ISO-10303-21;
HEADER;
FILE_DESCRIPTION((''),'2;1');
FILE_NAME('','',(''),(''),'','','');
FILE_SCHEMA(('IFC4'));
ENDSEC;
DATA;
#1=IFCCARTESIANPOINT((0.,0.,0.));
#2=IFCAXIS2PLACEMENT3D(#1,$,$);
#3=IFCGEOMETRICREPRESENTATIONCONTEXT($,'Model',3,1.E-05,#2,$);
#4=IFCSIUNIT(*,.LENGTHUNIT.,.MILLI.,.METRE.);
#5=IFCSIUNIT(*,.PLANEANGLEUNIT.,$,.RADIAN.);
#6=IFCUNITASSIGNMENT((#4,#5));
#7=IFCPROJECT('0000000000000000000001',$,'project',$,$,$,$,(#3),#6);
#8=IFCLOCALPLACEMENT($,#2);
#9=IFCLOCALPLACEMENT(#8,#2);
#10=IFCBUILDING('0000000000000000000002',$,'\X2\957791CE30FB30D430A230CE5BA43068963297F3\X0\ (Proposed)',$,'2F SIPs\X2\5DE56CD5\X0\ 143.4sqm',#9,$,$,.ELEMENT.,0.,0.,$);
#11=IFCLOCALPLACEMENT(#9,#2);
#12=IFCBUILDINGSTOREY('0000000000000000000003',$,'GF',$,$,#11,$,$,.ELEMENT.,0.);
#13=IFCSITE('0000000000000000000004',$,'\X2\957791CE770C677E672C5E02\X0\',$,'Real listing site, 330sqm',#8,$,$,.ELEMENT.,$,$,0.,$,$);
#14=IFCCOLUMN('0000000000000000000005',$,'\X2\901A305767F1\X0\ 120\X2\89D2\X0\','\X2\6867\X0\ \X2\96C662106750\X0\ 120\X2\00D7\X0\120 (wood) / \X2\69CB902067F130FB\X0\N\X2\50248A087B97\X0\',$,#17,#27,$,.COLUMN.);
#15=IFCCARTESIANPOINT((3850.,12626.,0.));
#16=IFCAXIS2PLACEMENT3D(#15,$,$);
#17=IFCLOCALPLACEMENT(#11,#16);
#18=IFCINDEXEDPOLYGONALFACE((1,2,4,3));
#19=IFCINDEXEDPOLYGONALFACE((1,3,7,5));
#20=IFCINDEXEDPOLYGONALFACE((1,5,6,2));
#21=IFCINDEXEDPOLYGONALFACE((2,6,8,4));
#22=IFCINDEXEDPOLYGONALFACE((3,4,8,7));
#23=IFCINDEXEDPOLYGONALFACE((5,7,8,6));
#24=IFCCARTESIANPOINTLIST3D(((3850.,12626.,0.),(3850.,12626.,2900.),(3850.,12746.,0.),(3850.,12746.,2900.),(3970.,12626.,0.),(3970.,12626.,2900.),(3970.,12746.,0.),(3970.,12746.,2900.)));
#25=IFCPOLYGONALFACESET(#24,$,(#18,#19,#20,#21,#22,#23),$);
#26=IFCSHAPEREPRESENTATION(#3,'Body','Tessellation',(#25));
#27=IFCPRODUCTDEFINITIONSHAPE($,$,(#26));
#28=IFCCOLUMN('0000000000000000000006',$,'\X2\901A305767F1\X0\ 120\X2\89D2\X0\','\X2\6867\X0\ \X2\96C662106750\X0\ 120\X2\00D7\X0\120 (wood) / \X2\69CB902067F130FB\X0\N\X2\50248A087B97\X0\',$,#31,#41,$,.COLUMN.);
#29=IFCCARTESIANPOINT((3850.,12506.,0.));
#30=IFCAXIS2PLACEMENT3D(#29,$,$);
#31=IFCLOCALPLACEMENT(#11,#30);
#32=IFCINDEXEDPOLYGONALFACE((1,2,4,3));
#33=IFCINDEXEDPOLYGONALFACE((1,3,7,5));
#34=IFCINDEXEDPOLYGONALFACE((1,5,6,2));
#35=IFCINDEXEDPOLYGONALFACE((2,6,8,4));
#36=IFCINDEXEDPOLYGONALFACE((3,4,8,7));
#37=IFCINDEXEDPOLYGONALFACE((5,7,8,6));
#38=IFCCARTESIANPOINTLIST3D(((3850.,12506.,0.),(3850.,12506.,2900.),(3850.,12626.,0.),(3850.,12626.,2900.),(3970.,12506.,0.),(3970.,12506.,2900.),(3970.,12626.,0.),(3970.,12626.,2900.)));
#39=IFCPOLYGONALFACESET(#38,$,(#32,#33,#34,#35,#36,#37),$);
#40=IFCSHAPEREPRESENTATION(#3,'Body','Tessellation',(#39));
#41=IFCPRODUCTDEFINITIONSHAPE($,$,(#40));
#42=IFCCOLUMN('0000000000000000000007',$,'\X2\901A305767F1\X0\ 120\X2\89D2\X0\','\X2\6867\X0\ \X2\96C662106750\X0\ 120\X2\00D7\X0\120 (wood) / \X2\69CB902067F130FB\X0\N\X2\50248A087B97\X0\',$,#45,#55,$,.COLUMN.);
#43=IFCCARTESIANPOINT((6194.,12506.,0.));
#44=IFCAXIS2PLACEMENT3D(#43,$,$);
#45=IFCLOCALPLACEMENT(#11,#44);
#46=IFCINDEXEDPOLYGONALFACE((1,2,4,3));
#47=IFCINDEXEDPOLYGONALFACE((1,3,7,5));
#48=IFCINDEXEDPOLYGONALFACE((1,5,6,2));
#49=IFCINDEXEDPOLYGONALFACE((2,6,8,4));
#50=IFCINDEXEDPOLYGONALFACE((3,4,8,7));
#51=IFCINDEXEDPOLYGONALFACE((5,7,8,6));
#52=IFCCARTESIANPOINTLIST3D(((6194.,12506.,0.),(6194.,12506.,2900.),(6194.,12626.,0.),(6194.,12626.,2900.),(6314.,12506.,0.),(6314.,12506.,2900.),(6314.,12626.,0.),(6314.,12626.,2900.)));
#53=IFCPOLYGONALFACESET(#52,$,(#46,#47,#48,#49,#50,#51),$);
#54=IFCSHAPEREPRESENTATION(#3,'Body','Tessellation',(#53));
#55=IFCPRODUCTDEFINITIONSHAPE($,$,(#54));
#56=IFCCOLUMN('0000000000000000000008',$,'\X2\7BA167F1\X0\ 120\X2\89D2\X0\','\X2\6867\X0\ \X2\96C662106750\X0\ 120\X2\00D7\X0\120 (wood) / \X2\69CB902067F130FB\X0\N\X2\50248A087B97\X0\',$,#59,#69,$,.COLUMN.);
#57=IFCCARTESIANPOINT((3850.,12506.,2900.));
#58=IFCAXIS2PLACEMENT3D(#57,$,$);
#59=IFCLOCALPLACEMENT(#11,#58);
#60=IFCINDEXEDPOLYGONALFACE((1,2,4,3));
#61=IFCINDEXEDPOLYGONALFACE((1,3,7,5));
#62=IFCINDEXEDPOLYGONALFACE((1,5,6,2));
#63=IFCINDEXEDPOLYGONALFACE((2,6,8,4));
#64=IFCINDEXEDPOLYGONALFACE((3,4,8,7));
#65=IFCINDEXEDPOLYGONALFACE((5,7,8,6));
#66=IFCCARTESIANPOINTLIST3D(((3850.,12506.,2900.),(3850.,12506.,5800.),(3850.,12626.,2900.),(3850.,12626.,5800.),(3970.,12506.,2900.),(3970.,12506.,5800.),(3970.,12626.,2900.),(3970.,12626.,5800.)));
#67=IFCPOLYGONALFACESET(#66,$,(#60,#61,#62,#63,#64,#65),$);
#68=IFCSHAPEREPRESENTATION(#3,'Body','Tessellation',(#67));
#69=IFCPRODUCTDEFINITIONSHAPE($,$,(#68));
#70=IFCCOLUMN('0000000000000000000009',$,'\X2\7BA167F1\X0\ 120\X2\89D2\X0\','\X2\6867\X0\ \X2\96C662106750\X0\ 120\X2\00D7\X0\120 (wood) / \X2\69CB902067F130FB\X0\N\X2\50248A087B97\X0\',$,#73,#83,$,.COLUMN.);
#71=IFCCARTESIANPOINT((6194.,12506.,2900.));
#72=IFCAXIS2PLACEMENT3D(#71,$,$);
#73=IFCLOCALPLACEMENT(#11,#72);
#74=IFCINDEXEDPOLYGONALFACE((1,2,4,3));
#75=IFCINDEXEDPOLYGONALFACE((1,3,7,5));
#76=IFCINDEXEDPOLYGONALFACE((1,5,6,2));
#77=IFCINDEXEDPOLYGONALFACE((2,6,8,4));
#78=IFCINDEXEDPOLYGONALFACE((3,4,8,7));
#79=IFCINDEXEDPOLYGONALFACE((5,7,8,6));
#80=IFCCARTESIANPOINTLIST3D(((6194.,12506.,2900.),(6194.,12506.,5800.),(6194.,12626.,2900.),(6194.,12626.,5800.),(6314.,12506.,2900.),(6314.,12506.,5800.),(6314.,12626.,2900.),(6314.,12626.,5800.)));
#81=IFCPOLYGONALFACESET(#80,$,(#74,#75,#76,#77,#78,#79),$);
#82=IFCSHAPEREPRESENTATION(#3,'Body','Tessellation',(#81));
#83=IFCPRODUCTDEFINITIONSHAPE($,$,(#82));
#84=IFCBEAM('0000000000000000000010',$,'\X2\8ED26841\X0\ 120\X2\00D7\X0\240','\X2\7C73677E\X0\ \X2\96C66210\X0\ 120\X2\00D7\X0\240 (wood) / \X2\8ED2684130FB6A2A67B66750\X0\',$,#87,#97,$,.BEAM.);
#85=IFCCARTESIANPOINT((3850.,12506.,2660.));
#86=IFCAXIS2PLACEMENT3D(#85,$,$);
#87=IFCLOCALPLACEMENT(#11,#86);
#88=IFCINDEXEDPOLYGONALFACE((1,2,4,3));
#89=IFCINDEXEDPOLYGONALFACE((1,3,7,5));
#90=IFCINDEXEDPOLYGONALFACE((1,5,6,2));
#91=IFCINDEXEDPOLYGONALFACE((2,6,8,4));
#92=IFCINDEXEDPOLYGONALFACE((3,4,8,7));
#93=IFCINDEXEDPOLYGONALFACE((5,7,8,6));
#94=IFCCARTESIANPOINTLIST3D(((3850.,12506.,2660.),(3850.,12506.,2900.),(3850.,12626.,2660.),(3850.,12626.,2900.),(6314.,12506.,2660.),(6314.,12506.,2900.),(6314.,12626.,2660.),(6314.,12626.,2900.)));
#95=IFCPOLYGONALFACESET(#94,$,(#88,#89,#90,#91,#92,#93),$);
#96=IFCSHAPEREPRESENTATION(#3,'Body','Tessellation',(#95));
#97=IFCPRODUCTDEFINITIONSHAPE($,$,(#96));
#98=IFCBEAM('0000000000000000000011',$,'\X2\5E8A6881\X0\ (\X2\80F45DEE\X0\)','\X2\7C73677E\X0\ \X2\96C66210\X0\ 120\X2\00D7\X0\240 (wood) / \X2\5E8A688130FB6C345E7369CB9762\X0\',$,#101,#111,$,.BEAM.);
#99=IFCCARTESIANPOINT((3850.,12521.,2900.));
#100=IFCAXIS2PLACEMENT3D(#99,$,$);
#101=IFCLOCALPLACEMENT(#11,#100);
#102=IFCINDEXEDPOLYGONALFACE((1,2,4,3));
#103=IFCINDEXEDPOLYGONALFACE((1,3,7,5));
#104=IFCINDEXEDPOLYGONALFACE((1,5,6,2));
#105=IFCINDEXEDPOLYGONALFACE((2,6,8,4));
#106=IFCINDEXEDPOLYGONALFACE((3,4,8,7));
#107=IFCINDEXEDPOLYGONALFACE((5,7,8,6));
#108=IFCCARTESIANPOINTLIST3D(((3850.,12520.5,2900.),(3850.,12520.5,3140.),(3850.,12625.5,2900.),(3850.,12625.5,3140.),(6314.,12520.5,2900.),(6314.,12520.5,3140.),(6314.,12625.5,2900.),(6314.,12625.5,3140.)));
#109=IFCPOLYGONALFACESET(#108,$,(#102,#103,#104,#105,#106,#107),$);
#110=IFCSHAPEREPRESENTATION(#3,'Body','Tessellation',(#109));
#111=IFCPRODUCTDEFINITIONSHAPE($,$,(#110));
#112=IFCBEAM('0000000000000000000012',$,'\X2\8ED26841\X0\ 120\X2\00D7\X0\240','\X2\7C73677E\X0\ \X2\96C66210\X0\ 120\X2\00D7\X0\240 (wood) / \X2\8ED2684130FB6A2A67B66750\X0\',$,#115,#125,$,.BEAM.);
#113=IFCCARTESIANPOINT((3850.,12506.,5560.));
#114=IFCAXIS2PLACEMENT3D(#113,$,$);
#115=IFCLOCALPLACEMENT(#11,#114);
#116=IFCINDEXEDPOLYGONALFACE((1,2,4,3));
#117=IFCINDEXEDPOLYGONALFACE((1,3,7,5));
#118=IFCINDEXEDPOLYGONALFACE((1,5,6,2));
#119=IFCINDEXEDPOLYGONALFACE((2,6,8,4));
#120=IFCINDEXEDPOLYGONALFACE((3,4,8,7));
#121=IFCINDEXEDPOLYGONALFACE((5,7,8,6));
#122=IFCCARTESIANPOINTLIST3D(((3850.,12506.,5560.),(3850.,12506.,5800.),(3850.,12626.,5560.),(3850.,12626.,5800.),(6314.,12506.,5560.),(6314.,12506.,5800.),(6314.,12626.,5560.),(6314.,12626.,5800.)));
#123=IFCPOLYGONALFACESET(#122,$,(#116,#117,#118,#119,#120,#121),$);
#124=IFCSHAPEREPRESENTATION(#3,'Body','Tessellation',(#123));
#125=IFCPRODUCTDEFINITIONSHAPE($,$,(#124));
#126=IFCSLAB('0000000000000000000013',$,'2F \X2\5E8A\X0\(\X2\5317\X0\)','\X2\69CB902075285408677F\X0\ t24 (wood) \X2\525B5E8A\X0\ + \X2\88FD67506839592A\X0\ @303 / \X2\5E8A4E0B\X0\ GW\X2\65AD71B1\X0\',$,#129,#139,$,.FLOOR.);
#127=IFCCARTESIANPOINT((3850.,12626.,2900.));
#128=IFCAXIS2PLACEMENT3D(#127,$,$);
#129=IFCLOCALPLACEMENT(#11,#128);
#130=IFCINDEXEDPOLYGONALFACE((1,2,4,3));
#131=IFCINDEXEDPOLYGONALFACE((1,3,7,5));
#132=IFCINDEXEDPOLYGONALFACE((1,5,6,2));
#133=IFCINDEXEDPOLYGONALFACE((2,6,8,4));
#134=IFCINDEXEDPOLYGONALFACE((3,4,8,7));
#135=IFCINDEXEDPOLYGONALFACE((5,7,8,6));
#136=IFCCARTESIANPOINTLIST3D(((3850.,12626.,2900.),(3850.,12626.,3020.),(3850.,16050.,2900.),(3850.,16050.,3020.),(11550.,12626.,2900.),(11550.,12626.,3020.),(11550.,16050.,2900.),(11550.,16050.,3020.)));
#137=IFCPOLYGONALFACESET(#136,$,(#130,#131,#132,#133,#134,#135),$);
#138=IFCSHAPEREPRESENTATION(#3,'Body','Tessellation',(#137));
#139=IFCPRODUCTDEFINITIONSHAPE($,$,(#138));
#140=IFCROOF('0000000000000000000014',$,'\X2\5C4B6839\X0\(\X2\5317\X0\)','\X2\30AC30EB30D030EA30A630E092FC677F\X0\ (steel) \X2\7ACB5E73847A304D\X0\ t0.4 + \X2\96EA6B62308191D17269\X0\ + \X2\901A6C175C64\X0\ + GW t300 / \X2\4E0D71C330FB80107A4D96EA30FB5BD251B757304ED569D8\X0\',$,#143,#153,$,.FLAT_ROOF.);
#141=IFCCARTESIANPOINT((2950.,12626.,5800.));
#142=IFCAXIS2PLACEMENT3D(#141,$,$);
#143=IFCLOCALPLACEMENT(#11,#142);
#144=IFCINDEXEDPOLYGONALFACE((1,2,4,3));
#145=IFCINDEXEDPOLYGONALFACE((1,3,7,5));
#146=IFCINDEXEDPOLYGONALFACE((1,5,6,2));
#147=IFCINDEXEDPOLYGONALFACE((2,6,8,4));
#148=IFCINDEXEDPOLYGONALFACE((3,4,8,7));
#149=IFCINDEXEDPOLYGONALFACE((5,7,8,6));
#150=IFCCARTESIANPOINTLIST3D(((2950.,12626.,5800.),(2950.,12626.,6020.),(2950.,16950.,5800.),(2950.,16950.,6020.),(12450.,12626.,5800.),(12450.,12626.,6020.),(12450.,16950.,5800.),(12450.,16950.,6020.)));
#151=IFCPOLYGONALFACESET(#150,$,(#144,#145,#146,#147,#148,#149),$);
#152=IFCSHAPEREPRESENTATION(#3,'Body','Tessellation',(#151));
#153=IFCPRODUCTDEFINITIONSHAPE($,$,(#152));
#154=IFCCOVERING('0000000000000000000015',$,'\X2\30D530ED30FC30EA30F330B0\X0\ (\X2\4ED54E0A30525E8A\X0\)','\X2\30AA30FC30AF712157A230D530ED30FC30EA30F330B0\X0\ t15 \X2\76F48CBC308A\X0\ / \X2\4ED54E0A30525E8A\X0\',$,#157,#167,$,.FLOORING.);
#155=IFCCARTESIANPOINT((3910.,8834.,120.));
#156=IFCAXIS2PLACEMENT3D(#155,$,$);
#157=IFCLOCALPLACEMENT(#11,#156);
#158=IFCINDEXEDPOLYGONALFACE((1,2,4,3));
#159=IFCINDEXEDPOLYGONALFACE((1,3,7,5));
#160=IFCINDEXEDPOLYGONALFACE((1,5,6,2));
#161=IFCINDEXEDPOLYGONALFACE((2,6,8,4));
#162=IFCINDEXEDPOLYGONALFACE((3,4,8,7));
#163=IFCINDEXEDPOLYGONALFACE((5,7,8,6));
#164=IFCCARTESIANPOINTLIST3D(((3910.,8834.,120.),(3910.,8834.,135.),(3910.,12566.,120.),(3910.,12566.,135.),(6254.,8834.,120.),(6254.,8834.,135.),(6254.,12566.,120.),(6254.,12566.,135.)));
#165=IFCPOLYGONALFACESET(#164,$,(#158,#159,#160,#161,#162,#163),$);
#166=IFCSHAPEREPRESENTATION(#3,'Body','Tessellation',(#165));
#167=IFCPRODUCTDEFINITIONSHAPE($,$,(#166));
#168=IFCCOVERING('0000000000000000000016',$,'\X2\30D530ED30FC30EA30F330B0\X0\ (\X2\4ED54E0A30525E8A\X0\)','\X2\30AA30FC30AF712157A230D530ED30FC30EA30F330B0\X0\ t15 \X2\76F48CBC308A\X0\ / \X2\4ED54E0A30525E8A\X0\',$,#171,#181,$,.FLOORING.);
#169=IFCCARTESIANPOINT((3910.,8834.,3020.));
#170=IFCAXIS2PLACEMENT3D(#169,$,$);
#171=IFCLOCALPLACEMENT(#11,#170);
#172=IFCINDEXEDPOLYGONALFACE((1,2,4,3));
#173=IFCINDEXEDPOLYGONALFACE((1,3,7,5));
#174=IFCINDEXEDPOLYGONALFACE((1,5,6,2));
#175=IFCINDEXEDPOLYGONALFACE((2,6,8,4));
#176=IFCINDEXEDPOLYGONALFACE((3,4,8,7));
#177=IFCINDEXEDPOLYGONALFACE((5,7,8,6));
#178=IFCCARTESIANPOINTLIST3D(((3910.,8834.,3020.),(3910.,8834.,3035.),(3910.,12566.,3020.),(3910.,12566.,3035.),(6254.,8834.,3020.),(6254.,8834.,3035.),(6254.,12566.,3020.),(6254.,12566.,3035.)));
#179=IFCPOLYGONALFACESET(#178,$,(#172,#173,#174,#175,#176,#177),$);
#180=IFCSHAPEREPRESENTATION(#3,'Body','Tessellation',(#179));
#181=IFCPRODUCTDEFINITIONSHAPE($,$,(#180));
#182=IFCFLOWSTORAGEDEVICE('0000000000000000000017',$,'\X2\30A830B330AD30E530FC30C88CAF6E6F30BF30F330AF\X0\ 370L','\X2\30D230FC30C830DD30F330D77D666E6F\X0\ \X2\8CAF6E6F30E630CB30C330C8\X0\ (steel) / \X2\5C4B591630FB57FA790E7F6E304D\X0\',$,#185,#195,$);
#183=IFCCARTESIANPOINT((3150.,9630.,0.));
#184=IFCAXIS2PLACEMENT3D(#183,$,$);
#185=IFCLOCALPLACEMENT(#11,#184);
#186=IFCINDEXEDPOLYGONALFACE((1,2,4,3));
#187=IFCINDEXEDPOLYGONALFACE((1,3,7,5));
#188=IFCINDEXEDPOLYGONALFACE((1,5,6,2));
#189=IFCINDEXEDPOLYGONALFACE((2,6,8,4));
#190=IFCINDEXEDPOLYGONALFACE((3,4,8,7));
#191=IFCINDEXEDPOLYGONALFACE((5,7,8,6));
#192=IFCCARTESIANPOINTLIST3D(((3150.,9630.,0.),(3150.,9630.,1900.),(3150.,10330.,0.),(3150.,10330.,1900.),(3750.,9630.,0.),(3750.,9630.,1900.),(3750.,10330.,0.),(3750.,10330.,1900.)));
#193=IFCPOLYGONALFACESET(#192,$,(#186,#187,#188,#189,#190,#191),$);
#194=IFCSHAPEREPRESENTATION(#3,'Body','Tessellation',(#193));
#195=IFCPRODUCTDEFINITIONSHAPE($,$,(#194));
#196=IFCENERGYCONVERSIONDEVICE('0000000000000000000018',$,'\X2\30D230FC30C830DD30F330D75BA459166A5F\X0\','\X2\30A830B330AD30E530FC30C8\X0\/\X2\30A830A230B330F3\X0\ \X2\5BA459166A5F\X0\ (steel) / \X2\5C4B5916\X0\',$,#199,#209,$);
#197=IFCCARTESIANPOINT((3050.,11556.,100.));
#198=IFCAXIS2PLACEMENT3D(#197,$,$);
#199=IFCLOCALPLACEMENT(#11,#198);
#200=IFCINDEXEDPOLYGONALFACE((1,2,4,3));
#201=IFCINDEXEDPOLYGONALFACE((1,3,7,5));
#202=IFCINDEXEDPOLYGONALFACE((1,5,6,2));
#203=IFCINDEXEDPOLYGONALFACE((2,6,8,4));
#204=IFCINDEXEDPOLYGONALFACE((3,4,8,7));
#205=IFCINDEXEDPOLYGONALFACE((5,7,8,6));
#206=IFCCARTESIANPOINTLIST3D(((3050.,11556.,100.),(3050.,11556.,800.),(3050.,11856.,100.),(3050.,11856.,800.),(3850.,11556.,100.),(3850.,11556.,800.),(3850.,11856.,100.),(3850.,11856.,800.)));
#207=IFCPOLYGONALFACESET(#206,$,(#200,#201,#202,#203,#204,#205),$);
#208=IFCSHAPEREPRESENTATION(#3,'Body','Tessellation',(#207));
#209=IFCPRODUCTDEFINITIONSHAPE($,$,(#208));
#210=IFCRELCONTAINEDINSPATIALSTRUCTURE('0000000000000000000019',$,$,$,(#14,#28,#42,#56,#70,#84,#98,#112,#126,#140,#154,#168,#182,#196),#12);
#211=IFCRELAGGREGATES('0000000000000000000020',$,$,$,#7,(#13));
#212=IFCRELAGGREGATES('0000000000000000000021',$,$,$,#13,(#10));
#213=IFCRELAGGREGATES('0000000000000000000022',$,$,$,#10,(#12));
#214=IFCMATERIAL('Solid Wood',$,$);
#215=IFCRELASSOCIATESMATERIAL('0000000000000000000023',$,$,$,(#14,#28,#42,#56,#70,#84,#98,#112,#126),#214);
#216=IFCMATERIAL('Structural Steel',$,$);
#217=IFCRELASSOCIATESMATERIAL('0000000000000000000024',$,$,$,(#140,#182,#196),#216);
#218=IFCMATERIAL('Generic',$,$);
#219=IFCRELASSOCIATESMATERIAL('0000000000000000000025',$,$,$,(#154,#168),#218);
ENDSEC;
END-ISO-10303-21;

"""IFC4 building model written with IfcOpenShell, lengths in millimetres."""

from ifc_helpers import new_model, si_unit, frame, frame_2d, origin, place, context, project, spatial, rectangle, extrude, material, element, save


model = new_model("IFC4")

# Units and contexts
model_context = context("Model", 3, precision=1e-05, world=origin())
ifc_project = project(units=[si_unit("LENGTHUNIT", "METRE", prefix="MILLI"), si_unit("PLANEANGLEUNIT", "RADIAN")], contexts=[model_context])

# Site, building, storey
site_placement = place(None, origin())
site = spatial("IfcSite", under=ifc_project, at=site_placement, Name="長野県松本市", ObjectType="Real listing site, 330sqm", CompositionType="ELEMENT", RefElevation=0.0)
building_placement = place(site_placement, origin())
building = spatial("IfcBuilding", under=site, at=building_placement, Name="長野・ピアノ室と防音 (Proposed)", ObjectType="2F SIPs工法 143.4sqm", CompositionType="ELEMENT", ElevationOfRefHeight=0.0, ElevationOfTerrain=0.0)
storey_placement = place(building_placement, origin())
storey = spatial("IfcBuildingStorey", under=building, at=storey_placement, Name="GF", CompositionType="ELEMENT", Elevation=0.0)

# Columns
ifc_material_1 = material(Name="Solid Wood")
column_1_placement = place(storey_placement, frame((3850.0, 12626.0, 0.0)))
element("IfcColumn", 1, at=column_1_placement, inside=storey, material=ifc_material_1, Name="通し柱 120角", Description="桧 集成材 120×120 (wood) / 構造柱・N値計算", PredefinedType="COLUMN", context=model_context, shape_type="SweptSolid", body=[
    extrude(rectangle(XDim=120.0, YDim=120.0, at=frame_2d((60.0, 60.0))), frame((3850.0, 12626.0, 0.0)), (0.0, 0.0, 1.0), 2900.0),
])
column_2_placement = place(storey_placement, frame((3850.0, 12506.0, 0.0)))
element("IfcColumn", 2, at=column_2_placement, inside=storey, material=ifc_material_1, Name="通し柱 120角", Description="桧 集成材 120×120 (wood) / 構造柱・N値計算", PredefinedType="COLUMN", context=model_context, shape_type="SweptSolid", body=[
    extrude(rectangle(XDim=120.0, YDim=120.0, at=frame_2d((60.0, 60.0))), frame((3850.0, 12506.0, 0.0)), (0.0, 0.0, 1.0), 2900.0),
])
column_3_placement = place(storey_placement, frame((6194.0, 12506.0, 0.0)))
element("IfcColumn", 3, at=column_3_placement, inside=storey, material=ifc_material_1, Name="通し柱 120角", Description="桧 集成材 120×120 (wood) / 構造柱・N値計算", PredefinedType="COLUMN", context=model_context, shape_type="SweptSolid", body=[
    extrude(rectangle(XDim=120.0, YDim=120.0, at=frame_2d((60.0, 60.0))), frame((6194.0, 12506.0, 0.0)), (0.0, 0.0, 1.0), 2900.0),
])
column_4_placement = place(storey_placement, frame((3850.0, 12506.0, 2900.0)))
element("IfcColumn", 4, at=column_4_placement, inside=storey, material=ifc_material_1, Name="管柱 120角", Description="桧 集成材 120×120 (wood) / 構造柱・N値計算", PredefinedType="COLUMN", context=model_context, shape_type="SweptSolid", body=[
    extrude(rectangle(XDim=120.0, YDim=120.0, at=frame_2d((60.0, 60.0))), frame((3850.0, 12506.0, 2900.0)), (0.0, 0.0, 1.0), 2900.0),
])
column_5_placement = place(storey_placement, frame((6194.0, 12506.0, 2900.0)))
element("IfcColumn", 5, at=column_5_placement, inside=storey, material=ifc_material_1, Name="管柱 120角", Description="桧 集成材 120×120 (wood) / 構造柱・N値計算", PredefinedType="COLUMN", context=model_context, shape_type="SweptSolid", body=[
    extrude(rectangle(XDim=120.0, YDim=120.0, at=frame_2d((60.0, 60.0))), frame((6194.0, 12506.0, 2900.0)), (0.0, 0.0, 1.0), 2900.0),
])

# Beams
beam_1_placement = place(storey_placement, frame((3850.0, 12506.0, 2660.0)))
element("IfcBeam", 6, at=beam_1_placement, inside=storey, material=ifc_material_1, Name="軒桁 120×240", Description="米松 集成 120×240 (wood) / 軒桁・横架材", PredefinedType="BEAM", context=model_context, shape_type="SweptSolid", body=[
    extrude(rectangle(XDim=2464.0, YDim=120.0, at=frame_2d((1232.0, 60.0))), frame((3850.0, 12506.0, 2660.0)), (0.0, 0.0, 1.0), 240.0),
])
beam_2_placement = place(storey_placement, frame((3850.0, 12521.0, 2900.0)))
element("IfcBeam", 7, at=beam_2_placement, inside=storey, material=ifc_material_1, Name="床梁 (胴差)", Description="米松 集成 120×240 (wood) / 床梁・水平構面", PredefinedType="BEAM", context=model_context, shape_type="SweptSolid", body=[
    extrude(rectangle(XDim=2464.0, YDim=105.0, at=frame_2d((1232.0, 52.0))), frame((3850.0, 12521.0, 2900.0)), (0.0, 0.0, 1.0), 240.0),
])
beam_3_placement = place(storey_placement, frame((3850.0, 12506.0, 5560.0)))
element("IfcBeam", 8, at=beam_3_placement, inside=storey, material=ifc_material_1, Name="軒桁 120×240", Description="米松 集成 120×240 (wood) / 軒桁・横架材", PredefinedType="BEAM", context=model_context, shape_type="SweptSolid", body=[
    extrude(rectangle(XDim=2464.0, YDim=120.0, at=frame_2d((1232.0, 60.0))), frame((3850.0, 12506.0, 5560.0)), (0.0, 0.0, 1.0), 240.0),
])

# Slab
slab_1_placement = place(storey_placement, frame((3850.0, 12626.0, 2900.0)))
element("IfcSlab", 9, at=slab_1_placement, inside=storey, material=ifc_material_1, Name="2F 床(北)", Description="構造用合板 t24 (wood) 剛床 + 製材根太 @303 / 床下 GW断熱", PredefinedType="FLOOR", context=model_context, shape_type="SweptSolid", body=[
    extrude(rectangle(XDim=7700.0, YDim=3424.0, at=frame_2d((3850.0, 1712.0))), frame((3850.0, 12626.0, 2900.0)), (0.0, 0.0, 1.0), 120.0),
])

# Roof
ifc_material_2 = material(Name="Structural Steel")
for number, where, name in (
    (10, (2950.0, 12626.0, 5800.0), "屋根(北)"),
):
    element("IfcRoof", number, at=place(storey_placement, frame(where)), inside=storey, material=ifc_material_2, Name=name, Description="ガルバリウム鋼板 (steel) 立平葺き t0.4 + 雪止め金物 + 通気層 + GW t300 / 不燃・耐積雪・寒冷地仕様", PredefinedType="FLAT_ROOF", context=model_context, shape_type="SweptSolid", body=[
        extrude(rectangle(XDim=9500.0, YDim=4324.0, at=frame_2d((4750.0, 2162.0))), frame((2950.0, 12626.0, 5800.0)), (0.0, 0.0, 1.0), 220.0),
    ])

# Coverings
ifc_material_3 = material(Name="Generic")
covering_1_placement = place(storey_placement, frame((3910.0, 8834.0, 120.0)))
element("IfcCovering", 11, at=covering_1_placement, inside=storey, material=ifc_material_3, Name="フローリング (仕上げ床)", Description="オーク無垢フローリング t15 直貼り / 仕上げ床", PredefinedType="FLOORING", context=model_context, shape_type="SweptSolid", body=[
    extrude(rectangle(XDim=2344.0, YDim=3732.0, at=frame_2d((1172.0, 1866.0))), frame((3910.0, 8834.0, 120.0)), (0.0, 0.0, 1.0), 15.0),
])
covering_2_placement = place(storey_placement, frame((3910.0, 8834.0, 3020.0)))
element("IfcCovering", 12, at=covering_2_placement, inside=storey, material=ifc_material_3, Name="フローリング (仕上げ床)", Description="オーク無垢フローリング t15 直貼り / 仕上げ床", PredefinedType="FLOORING", context=model_context, shape_type="SweptSolid", body=[
    extrude(rectangle(XDim=2344.0, YDim=3732.0, at=frame_2d((1172.0, 1866.0))), frame((3910.0, 8834.0, 3020.0)), (0.0, 0.0, 1.0), 15.0),
])

# Flow storage device
flow_storage_device_placement = place(storey_placement, frame((3150.0, 9630.0, 0.0)))
element("IfcFlowStorageDevice", 13, at=flow_storage_device_placement, inside=storey, material=ifc_material_2, Name="エコキュート貯湯タンク 370L", Description="ヒートポンプ給湯 貯湯ユニット (steel) / 屋外・基礎置き", context=model_context, shape_type="SweptSolid", body=[
    extrude(rectangle(XDim=600.0, YDim=700.0, at=frame_2d((300.0, 350.0))), frame((3150.0, 9630.0, 0.0)), (0.0, 0.0, 1.0), 1900.0),
])

# Energy conversion device
energy_conversion_device_placement = place(storey_placement, frame((3050.0, 11556.0, 100.0)))
element("IfcEnergyConversionDevice", 14, at=energy_conversion_device_placement, inside=storey, material=ifc_material_2, Name="ヒートポンプ室外機", Description="エコキュート/エアコン 室外機 (steel) / 屋外", context=model_context, shape_type="SweptSolid", body=[
    extrude(rectangle(XDim=800.0, YDim=300.0, at=frame_2d((400.0, 150.0))), frame((3050.0, 11556.0, 100.0)), (0.0, 0.0, 1.0), 700.0),
])

save(model, "model.ifc")
